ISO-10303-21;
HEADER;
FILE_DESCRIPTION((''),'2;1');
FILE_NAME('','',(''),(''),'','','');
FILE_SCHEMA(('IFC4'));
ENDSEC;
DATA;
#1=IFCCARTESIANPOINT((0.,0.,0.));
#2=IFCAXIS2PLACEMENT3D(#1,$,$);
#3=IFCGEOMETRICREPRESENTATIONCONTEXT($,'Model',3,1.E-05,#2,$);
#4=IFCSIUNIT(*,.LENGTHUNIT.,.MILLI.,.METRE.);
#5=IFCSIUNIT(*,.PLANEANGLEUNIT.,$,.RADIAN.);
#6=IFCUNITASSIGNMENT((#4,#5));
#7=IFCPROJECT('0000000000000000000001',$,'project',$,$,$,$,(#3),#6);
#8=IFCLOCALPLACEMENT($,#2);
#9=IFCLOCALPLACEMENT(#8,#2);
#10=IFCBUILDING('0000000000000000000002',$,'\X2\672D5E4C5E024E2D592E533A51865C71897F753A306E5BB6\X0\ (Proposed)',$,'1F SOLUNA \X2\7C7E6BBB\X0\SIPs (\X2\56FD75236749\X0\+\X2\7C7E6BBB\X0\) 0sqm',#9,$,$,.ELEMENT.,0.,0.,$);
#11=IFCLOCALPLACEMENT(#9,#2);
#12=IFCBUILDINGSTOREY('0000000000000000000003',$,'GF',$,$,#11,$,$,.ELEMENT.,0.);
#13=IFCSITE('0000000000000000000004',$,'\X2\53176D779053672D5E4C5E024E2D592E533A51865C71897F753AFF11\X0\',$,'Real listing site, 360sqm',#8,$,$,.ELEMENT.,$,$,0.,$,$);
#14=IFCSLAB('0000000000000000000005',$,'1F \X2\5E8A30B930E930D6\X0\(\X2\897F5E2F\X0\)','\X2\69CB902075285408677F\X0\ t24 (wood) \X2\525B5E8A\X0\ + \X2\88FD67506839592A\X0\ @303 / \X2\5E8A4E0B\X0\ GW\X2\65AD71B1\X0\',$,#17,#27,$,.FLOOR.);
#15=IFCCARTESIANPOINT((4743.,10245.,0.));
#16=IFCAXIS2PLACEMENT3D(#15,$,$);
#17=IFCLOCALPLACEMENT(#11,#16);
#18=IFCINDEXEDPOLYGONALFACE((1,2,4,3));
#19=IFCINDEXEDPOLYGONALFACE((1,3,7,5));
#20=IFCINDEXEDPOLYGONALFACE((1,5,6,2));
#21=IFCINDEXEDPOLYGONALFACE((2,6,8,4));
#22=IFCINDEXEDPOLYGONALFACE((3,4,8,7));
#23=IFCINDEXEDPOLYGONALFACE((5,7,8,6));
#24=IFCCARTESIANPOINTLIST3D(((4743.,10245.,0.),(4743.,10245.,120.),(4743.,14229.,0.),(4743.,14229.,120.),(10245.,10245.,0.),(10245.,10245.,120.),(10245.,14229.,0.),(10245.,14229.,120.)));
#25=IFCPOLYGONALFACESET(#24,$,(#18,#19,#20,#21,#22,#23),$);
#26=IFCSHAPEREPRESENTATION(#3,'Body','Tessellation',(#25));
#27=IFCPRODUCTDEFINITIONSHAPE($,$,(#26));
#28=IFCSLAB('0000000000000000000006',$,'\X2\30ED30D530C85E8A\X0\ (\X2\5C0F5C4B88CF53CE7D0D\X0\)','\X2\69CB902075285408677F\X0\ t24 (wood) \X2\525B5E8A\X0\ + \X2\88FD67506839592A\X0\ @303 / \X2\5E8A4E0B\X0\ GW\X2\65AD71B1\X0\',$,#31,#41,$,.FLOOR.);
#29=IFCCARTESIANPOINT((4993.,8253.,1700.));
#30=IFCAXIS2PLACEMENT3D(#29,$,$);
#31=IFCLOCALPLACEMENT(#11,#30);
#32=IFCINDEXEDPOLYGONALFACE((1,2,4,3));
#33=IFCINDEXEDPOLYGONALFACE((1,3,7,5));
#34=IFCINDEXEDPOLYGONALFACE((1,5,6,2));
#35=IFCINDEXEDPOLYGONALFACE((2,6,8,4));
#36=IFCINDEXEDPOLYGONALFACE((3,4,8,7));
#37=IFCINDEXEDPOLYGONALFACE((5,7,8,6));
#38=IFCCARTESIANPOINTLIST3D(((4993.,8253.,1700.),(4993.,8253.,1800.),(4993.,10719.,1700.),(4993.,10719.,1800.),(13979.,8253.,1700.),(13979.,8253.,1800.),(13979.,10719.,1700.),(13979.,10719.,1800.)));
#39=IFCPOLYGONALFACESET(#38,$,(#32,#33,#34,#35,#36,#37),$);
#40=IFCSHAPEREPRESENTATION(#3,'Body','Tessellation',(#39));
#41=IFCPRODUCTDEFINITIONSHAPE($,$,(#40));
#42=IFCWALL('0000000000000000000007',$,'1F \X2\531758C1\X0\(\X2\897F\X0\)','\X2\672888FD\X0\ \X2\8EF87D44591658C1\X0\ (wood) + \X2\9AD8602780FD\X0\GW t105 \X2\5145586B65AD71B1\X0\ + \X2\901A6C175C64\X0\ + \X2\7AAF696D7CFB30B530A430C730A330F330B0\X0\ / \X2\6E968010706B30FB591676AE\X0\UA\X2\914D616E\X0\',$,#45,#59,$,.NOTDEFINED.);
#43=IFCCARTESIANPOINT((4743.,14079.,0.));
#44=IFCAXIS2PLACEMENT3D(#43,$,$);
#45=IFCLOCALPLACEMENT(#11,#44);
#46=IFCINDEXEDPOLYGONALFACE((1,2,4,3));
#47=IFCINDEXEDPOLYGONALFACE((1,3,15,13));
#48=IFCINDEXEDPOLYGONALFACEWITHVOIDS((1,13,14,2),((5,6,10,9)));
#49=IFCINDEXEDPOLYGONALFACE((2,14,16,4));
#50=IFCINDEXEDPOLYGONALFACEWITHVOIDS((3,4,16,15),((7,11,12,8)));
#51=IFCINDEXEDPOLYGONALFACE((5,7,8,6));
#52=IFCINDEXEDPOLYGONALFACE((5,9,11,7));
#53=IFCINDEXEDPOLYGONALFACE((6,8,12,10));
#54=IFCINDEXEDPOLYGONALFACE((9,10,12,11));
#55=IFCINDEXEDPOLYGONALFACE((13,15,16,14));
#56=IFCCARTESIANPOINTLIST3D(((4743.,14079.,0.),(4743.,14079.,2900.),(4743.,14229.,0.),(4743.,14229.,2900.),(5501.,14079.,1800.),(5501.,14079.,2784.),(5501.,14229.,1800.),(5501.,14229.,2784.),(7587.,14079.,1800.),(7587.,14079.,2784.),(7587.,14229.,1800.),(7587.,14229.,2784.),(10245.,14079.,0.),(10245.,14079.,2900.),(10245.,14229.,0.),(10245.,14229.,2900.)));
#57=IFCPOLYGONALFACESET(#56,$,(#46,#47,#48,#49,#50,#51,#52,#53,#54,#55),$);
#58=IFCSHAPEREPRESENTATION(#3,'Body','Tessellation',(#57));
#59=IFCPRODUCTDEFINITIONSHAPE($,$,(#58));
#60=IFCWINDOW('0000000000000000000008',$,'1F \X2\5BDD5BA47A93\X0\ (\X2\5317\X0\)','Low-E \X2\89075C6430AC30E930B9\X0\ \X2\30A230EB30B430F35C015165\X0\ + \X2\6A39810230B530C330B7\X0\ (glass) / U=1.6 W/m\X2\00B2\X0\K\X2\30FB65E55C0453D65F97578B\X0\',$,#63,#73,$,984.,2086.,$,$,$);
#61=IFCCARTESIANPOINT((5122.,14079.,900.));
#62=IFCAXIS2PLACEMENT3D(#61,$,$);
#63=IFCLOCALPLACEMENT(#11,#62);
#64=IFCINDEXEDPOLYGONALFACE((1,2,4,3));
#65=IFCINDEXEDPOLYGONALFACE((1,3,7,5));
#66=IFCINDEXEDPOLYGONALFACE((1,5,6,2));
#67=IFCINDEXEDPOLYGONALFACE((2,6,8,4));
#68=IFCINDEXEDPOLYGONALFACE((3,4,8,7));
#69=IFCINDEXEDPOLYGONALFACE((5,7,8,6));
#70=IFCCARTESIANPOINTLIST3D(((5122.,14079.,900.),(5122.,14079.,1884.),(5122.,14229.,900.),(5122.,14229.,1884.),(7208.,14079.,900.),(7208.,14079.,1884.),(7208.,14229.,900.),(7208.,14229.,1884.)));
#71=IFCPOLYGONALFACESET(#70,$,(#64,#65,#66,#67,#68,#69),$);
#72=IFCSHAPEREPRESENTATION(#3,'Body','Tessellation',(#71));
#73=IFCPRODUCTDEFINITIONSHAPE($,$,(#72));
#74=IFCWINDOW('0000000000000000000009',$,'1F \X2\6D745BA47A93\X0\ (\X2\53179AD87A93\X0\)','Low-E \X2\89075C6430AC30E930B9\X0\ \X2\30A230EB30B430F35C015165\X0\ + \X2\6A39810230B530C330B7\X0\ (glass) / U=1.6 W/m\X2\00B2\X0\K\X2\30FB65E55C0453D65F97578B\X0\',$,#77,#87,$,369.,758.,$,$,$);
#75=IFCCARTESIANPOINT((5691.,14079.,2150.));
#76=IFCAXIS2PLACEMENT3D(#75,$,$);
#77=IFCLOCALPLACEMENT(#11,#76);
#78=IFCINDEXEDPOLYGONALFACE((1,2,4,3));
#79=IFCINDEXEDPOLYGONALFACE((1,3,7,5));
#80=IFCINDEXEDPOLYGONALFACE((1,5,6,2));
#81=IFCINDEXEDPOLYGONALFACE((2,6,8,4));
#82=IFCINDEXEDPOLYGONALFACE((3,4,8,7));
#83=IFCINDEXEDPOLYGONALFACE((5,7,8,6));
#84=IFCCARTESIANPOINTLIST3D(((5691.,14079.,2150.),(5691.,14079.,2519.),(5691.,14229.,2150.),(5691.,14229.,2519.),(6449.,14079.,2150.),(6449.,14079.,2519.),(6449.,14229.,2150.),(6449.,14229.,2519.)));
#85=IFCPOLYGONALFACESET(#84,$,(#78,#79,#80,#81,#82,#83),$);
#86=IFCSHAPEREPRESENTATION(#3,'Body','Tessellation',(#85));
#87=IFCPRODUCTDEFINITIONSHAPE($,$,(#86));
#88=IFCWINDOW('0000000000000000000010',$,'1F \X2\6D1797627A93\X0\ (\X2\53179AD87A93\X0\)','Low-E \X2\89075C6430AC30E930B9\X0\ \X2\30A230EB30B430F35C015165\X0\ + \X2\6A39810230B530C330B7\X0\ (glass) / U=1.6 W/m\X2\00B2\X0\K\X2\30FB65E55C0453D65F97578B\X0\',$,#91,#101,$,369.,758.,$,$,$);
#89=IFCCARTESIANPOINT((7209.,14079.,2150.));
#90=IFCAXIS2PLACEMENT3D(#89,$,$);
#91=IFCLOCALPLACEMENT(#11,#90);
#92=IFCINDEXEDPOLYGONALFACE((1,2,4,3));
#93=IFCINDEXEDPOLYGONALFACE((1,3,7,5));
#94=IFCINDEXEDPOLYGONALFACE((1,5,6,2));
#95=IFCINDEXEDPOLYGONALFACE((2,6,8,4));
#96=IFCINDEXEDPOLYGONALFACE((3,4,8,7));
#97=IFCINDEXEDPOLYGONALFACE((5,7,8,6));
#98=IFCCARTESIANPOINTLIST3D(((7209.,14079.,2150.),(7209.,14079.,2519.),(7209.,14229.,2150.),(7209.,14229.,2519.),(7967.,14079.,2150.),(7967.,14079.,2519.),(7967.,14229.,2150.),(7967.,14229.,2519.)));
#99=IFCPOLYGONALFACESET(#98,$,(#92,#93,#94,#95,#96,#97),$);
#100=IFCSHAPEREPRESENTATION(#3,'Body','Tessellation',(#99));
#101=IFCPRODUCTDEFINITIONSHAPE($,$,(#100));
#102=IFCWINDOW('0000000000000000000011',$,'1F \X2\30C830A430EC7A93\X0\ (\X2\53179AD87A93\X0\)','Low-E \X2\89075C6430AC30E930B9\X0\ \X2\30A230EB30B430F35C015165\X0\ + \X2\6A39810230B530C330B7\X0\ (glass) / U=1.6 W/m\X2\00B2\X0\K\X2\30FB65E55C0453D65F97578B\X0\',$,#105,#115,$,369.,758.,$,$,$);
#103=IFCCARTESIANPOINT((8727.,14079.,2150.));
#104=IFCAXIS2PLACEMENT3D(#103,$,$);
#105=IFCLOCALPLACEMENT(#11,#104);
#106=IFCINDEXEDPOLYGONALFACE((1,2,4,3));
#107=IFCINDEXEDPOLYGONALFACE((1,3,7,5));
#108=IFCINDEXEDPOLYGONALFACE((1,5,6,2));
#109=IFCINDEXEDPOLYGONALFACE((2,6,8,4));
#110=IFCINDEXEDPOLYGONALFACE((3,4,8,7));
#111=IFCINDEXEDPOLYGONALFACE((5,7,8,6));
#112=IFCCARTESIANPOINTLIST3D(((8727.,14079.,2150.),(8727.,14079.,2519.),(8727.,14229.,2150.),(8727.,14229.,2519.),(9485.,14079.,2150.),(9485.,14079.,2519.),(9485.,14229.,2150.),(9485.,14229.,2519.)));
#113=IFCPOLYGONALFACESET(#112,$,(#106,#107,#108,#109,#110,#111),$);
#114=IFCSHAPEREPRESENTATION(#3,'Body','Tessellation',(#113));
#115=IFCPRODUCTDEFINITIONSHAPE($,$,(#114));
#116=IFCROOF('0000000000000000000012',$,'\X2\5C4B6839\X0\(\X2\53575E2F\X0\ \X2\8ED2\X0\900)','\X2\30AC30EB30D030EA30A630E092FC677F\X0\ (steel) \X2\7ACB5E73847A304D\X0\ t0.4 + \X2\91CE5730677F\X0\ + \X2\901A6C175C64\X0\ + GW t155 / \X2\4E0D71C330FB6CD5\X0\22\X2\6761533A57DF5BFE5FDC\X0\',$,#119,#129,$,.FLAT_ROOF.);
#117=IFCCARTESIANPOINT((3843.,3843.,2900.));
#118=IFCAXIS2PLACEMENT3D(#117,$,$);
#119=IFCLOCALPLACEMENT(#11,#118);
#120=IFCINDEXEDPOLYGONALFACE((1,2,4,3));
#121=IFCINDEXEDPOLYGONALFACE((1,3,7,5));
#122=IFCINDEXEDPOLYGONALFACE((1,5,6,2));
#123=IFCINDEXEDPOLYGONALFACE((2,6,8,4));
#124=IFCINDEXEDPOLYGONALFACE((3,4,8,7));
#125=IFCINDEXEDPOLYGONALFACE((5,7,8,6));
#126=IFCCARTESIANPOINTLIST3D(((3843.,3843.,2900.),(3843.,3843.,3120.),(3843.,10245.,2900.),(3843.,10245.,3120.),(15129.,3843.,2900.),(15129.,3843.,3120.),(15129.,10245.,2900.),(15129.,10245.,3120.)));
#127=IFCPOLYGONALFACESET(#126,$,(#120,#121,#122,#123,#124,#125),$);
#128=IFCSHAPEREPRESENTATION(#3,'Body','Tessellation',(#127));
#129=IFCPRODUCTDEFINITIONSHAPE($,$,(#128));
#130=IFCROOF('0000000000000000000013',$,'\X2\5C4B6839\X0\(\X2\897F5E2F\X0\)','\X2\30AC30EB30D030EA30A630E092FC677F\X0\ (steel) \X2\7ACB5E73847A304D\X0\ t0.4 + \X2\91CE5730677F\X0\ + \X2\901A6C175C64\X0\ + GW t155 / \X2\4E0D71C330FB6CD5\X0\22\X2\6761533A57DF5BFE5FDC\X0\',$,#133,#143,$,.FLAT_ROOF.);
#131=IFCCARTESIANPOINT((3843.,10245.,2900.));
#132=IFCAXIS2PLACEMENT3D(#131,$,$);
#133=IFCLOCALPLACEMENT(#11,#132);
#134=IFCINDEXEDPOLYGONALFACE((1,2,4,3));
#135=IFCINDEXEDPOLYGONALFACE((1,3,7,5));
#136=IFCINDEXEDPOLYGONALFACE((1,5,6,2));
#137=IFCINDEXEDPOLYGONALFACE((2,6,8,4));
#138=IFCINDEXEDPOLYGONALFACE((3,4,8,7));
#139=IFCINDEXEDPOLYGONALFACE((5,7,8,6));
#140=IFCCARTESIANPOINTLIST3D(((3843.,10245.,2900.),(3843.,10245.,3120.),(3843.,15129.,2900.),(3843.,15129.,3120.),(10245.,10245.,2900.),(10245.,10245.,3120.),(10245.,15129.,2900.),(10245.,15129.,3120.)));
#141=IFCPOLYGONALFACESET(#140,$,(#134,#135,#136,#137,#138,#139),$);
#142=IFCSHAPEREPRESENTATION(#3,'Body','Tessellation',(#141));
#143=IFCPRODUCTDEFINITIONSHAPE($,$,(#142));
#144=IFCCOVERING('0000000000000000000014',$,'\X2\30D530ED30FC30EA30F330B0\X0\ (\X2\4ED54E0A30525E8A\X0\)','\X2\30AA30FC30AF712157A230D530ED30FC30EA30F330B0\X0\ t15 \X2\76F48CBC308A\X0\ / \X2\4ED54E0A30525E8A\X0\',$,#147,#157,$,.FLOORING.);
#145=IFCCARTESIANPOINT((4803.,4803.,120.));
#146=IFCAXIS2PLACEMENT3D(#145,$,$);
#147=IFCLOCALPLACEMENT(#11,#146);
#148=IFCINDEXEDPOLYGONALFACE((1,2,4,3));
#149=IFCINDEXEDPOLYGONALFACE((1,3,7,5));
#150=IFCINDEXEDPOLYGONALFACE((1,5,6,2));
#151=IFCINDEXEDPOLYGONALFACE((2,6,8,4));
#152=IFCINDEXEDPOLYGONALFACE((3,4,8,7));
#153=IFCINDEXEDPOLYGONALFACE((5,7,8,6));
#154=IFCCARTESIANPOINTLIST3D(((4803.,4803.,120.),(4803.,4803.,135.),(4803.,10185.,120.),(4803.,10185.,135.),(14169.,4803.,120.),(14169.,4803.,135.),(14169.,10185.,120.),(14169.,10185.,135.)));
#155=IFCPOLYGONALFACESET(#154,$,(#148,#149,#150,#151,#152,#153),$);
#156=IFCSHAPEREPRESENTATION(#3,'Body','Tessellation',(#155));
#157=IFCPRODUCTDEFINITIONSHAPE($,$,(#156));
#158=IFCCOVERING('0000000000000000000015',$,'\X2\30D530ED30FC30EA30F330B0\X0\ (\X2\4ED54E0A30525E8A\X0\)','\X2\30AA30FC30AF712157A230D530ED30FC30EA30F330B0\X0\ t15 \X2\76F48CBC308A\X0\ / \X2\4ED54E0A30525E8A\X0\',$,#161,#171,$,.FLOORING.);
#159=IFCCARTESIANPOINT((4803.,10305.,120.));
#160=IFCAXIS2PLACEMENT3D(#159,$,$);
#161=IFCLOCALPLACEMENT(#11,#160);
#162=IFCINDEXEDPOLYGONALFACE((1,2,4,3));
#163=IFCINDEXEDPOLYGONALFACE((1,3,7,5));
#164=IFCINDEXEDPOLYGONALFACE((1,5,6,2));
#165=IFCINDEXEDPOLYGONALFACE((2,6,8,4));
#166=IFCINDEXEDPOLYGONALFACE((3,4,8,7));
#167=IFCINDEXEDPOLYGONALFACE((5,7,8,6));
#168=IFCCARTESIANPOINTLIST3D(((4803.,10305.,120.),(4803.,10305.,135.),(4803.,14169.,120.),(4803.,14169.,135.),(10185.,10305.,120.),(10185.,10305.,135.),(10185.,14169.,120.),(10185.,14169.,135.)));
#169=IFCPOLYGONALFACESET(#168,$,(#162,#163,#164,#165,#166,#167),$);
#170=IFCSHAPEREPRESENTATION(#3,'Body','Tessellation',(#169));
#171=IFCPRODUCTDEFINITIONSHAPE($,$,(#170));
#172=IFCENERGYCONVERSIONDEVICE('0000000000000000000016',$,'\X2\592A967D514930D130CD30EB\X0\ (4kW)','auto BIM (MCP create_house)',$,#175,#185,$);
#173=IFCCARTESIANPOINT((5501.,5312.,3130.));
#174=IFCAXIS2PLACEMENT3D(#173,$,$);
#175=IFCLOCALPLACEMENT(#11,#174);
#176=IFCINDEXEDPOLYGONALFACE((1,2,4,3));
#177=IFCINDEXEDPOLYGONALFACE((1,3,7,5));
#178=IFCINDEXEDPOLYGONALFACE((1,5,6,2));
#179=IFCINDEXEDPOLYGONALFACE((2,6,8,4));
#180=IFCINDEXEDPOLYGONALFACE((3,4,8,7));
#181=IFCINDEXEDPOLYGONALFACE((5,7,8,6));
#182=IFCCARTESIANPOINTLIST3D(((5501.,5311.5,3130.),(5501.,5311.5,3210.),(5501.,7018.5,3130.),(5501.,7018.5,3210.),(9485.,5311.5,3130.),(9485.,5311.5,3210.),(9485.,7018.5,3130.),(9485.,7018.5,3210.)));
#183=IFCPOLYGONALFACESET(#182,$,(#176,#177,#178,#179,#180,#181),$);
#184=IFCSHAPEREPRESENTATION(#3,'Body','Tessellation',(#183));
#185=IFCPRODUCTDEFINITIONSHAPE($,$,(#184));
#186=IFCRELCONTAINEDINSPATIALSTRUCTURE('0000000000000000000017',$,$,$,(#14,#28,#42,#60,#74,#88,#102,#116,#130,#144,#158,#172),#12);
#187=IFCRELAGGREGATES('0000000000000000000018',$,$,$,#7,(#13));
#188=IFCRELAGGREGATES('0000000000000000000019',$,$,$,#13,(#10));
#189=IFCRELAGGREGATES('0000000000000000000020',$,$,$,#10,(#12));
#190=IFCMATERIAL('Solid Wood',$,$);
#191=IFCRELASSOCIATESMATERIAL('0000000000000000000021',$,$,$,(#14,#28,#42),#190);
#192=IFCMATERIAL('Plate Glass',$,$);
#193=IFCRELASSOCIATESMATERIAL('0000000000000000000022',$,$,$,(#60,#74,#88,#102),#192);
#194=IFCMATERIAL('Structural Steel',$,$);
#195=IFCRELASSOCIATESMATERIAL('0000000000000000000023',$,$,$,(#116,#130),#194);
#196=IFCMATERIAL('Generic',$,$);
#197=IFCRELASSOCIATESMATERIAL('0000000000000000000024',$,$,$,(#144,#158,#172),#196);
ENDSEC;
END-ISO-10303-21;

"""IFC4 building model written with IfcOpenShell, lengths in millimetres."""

from ifc_helpers import new_model, si_unit, frame, frame_2d, origin, place, context, project, spatial, rectangle, extrude, material, element, fill, save


model = new_model("IFC4")

# Units and contexts
model_context = context("Model", 3, precision=1e-05, world=origin())
ifc_project = project(units=[si_unit("LENGTHUNIT", "METRE", prefix="MILLI"), si_unit("PLANEANGLEUNIT", "RADIAN")], contexts=[model_context])

# Site, building, storey
site_placement = place(None, origin())
site = spatial("IfcSite", under=ifc_project, at=site_placement, Name="北海道札幌市中央区円山西町１", ObjectType="Real listing site, 360sqm", CompositionType="ELEMENT", RefElevation=0.0)
building_placement = place(site_placement, origin())
building = spatial("IfcBuilding", under=site, at=building_placement, Name="札幌市中央区円山西町の家 (Proposed)", ObjectType="1F SOLUNA 籾殻SIPs (国産杉+籾殻) 0sqm", CompositionType="ELEMENT", ElevationOfRefHeight=0.0, ElevationOfTerrain=0.0)
storey_placement = place(building_placement, origin())
storey = spatial("IfcBuildingStorey", under=building, at=storey_placement, Name="GF", CompositionType="ELEMENT", Elevation=0.0)

# Slabs
ifc_material_1 = material(Name="Solid Wood")
slab_1_placement = place(storey_placement, frame((4743.0, 10245.0, 0.0)))
element("IfcSlab", 1, at=slab_1_placement, inside=storey, material=ifc_material_1, Name="1F 床スラブ(西帯)", Description="構造用合板 t24 (wood) 剛床 + 製材根太 @303 / 床下 GW断熱", PredefinedType="FLOOR", context=model_context, shape_type="SweptSolid", body=[
    extrude(rectangle(XDim=5502.0, YDim=3984.0, at=frame_2d((2751.0, 1992.0))), frame((4743.0, 10245.0, 0.0)), (0.0, 0.0, 1.0), 120.0),
])
slab_2_placement = place(storey_placement, frame((4993.0, 8253.0, 1700.0)))
element("IfcSlab", 2, at=slab_2_placement, inside=storey, material=ifc_material_1, Name="ロフト床 (小屋裏収納)", Description="構造用合板 t24 (wood) 剛床 + 製材根太 @303 / 床下 GW断熱", PredefinedType="FLOOR", context=model_context, shape_type="SweptSolid", body=[
    extrude(rectangle(XDim=8986.0, YDim=2466.0, at=frame_2d((4493.0, 1233.0))), frame((4993.0, 8253.0, 1700.0)), (0.0, 0.0, 1.0), 100.0),
])

# Shared definitions
ifc_material_2 = material(Name="Plate Glass")

# Wall, openings, windows
wall_1_placement = place(storey_placement, frame((4743.0, 14079.0, 0.0)))
wall_1 = element("IfcWall", 3, at=wall_1_placement, inside=storey, material=ifc_material_1, Name="1F 北壁(西)", Description="木製 軸組外壁 (wood) + 高性能GW t105 充填断熱 + 通気層 + 窯業系サイディング / 準耐火・外皮UA配慮", PredefinedType="NOTDEFINED", context=model_context, shape_type="SweptSolid", body=[
    extrude(rectangle(XDim=5502.0, YDim=150.0, at=frame_2d((2751.0, 75.0))), frame((4743.0, 14079.0, 0.0)), (0.0, 0.0, 1.0), 2900.0),
])
opening_1_placement = place(storey_placement, frame((5122.0, 14079.0, 900.0)))
opening_1 = element("IfcOpeningElement", 4, at=opening_1_placement, cuts=wall_1, PredefinedType="NOTDEFINED", context=model_context, shape_type="SweptSolid", body=[
    extrude(rectangle(XDim=2086.0, YDim=150.0, at=frame_2d((1043.0, 75.0))), frame((5122.0, 14079.0, 900.0)), (0.0, 0.0, 1.0), 984.0),
])
opening_2_placement = place(storey_placement, frame((5691.0, 14079.0, 2150.0)))
opening_2 = element("IfcOpeningElement", 5, at=opening_2_placement, cuts=wall_1, PredefinedType="NOTDEFINED", context=model_context, shape_type="SweptSolid", body=[
    extrude(rectangle(XDim=758.0, YDim=150.0, at=frame_2d((379.0, 75.0))), frame((5691.0, 14079.0, 2150.0)), (0.0, 0.0, 1.0), 369.0),
])
opening_3_placement = place(storey_placement, frame((7209.0, 14079.0, 2150.0)))
opening_3 = element("IfcOpeningElement", 6, at=opening_3_placement, cuts=wall_1, PredefinedType="NOTDEFINED", context=model_context, shape_type="SweptSolid", body=[
    extrude(rectangle(XDim=758.0, YDim=150.0, at=frame_2d((379.0, 75.0))), frame((7209.0, 14079.0, 2150.0)), (0.0, 0.0, 1.0), 369.0),
])
opening_4_placement = place(storey_placement, frame((8727.0, 14079.0, 2150.0)))
opening_4 = element("IfcOpeningElement", 7, at=opening_4_placement, cuts=wall_1, PredefinedType="NOTDEFINED", context=model_context, shape_type="SweptSolid", body=[
    extrude(rectangle(XDim=758.0, YDim=150.0, at=frame_2d((379.0, 75.0))), frame((8727.0, 14079.0, 2150.0)), (0.0, 0.0, 1.0), 369.0),
])
window_1_placement = place(storey_placement, frame((5122.0, 14079.0, 900.0)))
window_1 = element("IfcWindow", 8, at=window_1_placement, inside=storey, material=ifc_material_2, Name="1F 寝室窓 (北)", Description="Low-E 複層ガラス アルゴン封入 + 樹脂サッシ (glass) / U=1.6 W/m²K・日射取得型", OverallHeight=984.0, OverallWidth=2086.0, context=model_context, shape_type="SweptSolid", body=[
    extrude(rectangle(XDim=2086.0, YDim=150.0, at=frame_2d((1043.0, 75.0))), frame((5122.0, 14079.0, 900.0)), (0.0, 0.0, 1.0), 984.0),
])
fill(opening_1, window_1)
window_2_placement = place(storey_placement, frame((5691.0, 14079.0, 2150.0)))
window_2 = element("IfcWindow", 9, at=window_2_placement, inside=storey, material=ifc_material_2, Name="1F 浴室窓 (北高窓)", Description="Low-E 複層ガラス アルゴン封入 + 樹脂サッシ (glass) / U=1.6 W/m²K・日射取得型", OverallHeight=369.0, OverallWidth=758.0, context=model_context, shape_type="SweptSolid", body=[
    extrude(rectangle(XDim=758.0, YDim=150.0, at=frame_2d((379.0, 75.0))), frame((5691.0, 14079.0, 2150.0)), (0.0, 0.0, 1.0), 369.0),
])
fill(opening_2, window_2)
window_3_placement = place(storey_placement, frame((7209.0, 14079.0, 2150.0)))
window_3 = element("IfcWindow", 10, at=window_3_placement, inside=storey, material=ifc_material_2, Name="1F 洗面窓 (北高窓)", Description="Low-E 複層ガラス アルゴン封入 + 樹脂サッシ (glass) / U=1.6 W/m²K・日射取得型", OverallHeight=369.0, OverallWidth=758.0, context=model_context, shape_type="SweptSolid", body=[
    extrude(rectangle(XDim=758.0, YDim=150.0, at=frame_2d((379.0, 75.0))), frame((7209.0, 14079.0, 2150.0)), (0.0, 0.0, 1.0), 369.0),
])
fill(opening_3, window_3)
window_4_placement = place(storey_placement, frame((8727.0, 14079.0, 2150.0)))
window_4 = element("IfcWindow", 11, at=window_4_placement, inside=storey, material=ifc_material_2, Name="1F トイレ窓 (北高窓)", Description="Low-E 複層ガラス アルゴン封入 + 樹脂サッシ (glass) / U=1.6 W/m²K・日射取得型", OverallHeight=369.0, OverallWidth=758.0, context=model_context, shape_type="SweptSolid", body=[
    extrude(rectangle(XDim=758.0, YDim=150.0, at=frame_2d((379.0, 75.0))), frame((8727.0, 14079.0, 2150.0)), (0.0, 0.0, 1.0), 369.0),
])
fill(opening_4, window_4)

# Roofs
ifc_material_3 = material(Name="Structural Steel")
roof_1_placement = place(storey_placement, frame((3843.0, 3843.0, 2900.0)))
element("IfcRoof", 12, at=roof_1_placement, inside=storey, material=ifc_material_3, Name="屋根(南帯 軒900)", Description="ガルバリウム鋼板 (steel) 立平葺き t0.4 + 野地板 + 通気層 + GW t155 / 不燃・法22条区域対応", PredefinedType="FLAT_ROOF", context=model_context, shape_type="SweptSolid", body=[
    extrude(rectangle(XDim=11286.0, YDim=6402.0, at=frame_2d((5643.0, 3201.0))), frame((3843.0, 3843.0, 2900.0)), (0.0, 0.0, 1.0), 220.0),
])
roof_2_placement = place(storey_placement, frame((3843.0, 10245.0, 2900.0)))
element("IfcRoof", 13, at=roof_2_placement, inside=storey, material=ifc_material_3, Name="屋根(西帯)", Description="ガルバリウム鋼板 (steel) 立平葺き t0.4 + 野地板 + 通気層 + GW t155 / 不燃・法22条区域対応", PredefinedType="FLAT_ROOF", context=model_context, shape_type="SweptSolid", body=[
    extrude(rectangle(XDim=6402.0, YDim=4884.0, at=frame_2d((3201.0, 2442.0))), frame((3843.0, 10245.0, 2900.0)), (0.0, 0.0, 1.0), 220.0),
])

# Coverings
ifc_material_4 = material(Name="Generic")
covering_1_placement = place(storey_placement, frame((4803.0, 4803.0, 120.0)))
element("IfcCovering", 14, at=covering_1_placement, inside=storey, material=ifc_material_4, Name="フローリング (仕上げ床)", Description="オーク無垢フローリング t15 直貼り / 仕上げ床", PredefinedType="FLOORING", context=model_context, shape_type="SweptSolid", body=[
    extrude(rectangle(XDim=9366.0, YDim=5382.0, at=frame_2d((4683.0, 2691.0))), frame((4803.0, 4803.0, 120.0)), (0.0, 0.0, 1.0), 15.0),
])
covering_2_placement = place(storey_placement, frame((4803.0, 10305.0, 120.0)))
element("IfcCovering", 15, at=covering_2_placement, inside=storey, material=ifc_material_4, Name="フローリング (仕上げ床)", Description="オーク無垢フローリング t15 直貼り / 仕上げ床", PredefinedType="FLOORING", context=model_context, shape_type="SweptSolid", body=[
    extrude(rectangle(XDim=5382.0, YDim=3864.0, at=frame_2d((2691.0, 1932.0))), frame((4803.0, 10305.0, 120.0)), (0.0, 0.0, 1.0), 15.0),
])

# Energy conversion device
energy_conversion_device_placement = place(storey_placement, frame((5501.0, 5312.0, 3130.0)))
element("IfcEnergyConversionDevice", 16, at=energy_conversion_device_placement, inside=storey, material=ifc_material_4, Name="太陽光パネル (4kW)", Description="auto BIM (MCP create_house)", context=model_context, shape_type="SweptSolid", body=[
    extrude(rectangle(XDim=3984.0, YDim=1707.0, at=frame_2d((1992.0, 853.0))), frame((5501.0, 5312.0, 3130.0)), (0.0, 0.0, 1.0), 80.0),
])

save(model, "model.ifc")
